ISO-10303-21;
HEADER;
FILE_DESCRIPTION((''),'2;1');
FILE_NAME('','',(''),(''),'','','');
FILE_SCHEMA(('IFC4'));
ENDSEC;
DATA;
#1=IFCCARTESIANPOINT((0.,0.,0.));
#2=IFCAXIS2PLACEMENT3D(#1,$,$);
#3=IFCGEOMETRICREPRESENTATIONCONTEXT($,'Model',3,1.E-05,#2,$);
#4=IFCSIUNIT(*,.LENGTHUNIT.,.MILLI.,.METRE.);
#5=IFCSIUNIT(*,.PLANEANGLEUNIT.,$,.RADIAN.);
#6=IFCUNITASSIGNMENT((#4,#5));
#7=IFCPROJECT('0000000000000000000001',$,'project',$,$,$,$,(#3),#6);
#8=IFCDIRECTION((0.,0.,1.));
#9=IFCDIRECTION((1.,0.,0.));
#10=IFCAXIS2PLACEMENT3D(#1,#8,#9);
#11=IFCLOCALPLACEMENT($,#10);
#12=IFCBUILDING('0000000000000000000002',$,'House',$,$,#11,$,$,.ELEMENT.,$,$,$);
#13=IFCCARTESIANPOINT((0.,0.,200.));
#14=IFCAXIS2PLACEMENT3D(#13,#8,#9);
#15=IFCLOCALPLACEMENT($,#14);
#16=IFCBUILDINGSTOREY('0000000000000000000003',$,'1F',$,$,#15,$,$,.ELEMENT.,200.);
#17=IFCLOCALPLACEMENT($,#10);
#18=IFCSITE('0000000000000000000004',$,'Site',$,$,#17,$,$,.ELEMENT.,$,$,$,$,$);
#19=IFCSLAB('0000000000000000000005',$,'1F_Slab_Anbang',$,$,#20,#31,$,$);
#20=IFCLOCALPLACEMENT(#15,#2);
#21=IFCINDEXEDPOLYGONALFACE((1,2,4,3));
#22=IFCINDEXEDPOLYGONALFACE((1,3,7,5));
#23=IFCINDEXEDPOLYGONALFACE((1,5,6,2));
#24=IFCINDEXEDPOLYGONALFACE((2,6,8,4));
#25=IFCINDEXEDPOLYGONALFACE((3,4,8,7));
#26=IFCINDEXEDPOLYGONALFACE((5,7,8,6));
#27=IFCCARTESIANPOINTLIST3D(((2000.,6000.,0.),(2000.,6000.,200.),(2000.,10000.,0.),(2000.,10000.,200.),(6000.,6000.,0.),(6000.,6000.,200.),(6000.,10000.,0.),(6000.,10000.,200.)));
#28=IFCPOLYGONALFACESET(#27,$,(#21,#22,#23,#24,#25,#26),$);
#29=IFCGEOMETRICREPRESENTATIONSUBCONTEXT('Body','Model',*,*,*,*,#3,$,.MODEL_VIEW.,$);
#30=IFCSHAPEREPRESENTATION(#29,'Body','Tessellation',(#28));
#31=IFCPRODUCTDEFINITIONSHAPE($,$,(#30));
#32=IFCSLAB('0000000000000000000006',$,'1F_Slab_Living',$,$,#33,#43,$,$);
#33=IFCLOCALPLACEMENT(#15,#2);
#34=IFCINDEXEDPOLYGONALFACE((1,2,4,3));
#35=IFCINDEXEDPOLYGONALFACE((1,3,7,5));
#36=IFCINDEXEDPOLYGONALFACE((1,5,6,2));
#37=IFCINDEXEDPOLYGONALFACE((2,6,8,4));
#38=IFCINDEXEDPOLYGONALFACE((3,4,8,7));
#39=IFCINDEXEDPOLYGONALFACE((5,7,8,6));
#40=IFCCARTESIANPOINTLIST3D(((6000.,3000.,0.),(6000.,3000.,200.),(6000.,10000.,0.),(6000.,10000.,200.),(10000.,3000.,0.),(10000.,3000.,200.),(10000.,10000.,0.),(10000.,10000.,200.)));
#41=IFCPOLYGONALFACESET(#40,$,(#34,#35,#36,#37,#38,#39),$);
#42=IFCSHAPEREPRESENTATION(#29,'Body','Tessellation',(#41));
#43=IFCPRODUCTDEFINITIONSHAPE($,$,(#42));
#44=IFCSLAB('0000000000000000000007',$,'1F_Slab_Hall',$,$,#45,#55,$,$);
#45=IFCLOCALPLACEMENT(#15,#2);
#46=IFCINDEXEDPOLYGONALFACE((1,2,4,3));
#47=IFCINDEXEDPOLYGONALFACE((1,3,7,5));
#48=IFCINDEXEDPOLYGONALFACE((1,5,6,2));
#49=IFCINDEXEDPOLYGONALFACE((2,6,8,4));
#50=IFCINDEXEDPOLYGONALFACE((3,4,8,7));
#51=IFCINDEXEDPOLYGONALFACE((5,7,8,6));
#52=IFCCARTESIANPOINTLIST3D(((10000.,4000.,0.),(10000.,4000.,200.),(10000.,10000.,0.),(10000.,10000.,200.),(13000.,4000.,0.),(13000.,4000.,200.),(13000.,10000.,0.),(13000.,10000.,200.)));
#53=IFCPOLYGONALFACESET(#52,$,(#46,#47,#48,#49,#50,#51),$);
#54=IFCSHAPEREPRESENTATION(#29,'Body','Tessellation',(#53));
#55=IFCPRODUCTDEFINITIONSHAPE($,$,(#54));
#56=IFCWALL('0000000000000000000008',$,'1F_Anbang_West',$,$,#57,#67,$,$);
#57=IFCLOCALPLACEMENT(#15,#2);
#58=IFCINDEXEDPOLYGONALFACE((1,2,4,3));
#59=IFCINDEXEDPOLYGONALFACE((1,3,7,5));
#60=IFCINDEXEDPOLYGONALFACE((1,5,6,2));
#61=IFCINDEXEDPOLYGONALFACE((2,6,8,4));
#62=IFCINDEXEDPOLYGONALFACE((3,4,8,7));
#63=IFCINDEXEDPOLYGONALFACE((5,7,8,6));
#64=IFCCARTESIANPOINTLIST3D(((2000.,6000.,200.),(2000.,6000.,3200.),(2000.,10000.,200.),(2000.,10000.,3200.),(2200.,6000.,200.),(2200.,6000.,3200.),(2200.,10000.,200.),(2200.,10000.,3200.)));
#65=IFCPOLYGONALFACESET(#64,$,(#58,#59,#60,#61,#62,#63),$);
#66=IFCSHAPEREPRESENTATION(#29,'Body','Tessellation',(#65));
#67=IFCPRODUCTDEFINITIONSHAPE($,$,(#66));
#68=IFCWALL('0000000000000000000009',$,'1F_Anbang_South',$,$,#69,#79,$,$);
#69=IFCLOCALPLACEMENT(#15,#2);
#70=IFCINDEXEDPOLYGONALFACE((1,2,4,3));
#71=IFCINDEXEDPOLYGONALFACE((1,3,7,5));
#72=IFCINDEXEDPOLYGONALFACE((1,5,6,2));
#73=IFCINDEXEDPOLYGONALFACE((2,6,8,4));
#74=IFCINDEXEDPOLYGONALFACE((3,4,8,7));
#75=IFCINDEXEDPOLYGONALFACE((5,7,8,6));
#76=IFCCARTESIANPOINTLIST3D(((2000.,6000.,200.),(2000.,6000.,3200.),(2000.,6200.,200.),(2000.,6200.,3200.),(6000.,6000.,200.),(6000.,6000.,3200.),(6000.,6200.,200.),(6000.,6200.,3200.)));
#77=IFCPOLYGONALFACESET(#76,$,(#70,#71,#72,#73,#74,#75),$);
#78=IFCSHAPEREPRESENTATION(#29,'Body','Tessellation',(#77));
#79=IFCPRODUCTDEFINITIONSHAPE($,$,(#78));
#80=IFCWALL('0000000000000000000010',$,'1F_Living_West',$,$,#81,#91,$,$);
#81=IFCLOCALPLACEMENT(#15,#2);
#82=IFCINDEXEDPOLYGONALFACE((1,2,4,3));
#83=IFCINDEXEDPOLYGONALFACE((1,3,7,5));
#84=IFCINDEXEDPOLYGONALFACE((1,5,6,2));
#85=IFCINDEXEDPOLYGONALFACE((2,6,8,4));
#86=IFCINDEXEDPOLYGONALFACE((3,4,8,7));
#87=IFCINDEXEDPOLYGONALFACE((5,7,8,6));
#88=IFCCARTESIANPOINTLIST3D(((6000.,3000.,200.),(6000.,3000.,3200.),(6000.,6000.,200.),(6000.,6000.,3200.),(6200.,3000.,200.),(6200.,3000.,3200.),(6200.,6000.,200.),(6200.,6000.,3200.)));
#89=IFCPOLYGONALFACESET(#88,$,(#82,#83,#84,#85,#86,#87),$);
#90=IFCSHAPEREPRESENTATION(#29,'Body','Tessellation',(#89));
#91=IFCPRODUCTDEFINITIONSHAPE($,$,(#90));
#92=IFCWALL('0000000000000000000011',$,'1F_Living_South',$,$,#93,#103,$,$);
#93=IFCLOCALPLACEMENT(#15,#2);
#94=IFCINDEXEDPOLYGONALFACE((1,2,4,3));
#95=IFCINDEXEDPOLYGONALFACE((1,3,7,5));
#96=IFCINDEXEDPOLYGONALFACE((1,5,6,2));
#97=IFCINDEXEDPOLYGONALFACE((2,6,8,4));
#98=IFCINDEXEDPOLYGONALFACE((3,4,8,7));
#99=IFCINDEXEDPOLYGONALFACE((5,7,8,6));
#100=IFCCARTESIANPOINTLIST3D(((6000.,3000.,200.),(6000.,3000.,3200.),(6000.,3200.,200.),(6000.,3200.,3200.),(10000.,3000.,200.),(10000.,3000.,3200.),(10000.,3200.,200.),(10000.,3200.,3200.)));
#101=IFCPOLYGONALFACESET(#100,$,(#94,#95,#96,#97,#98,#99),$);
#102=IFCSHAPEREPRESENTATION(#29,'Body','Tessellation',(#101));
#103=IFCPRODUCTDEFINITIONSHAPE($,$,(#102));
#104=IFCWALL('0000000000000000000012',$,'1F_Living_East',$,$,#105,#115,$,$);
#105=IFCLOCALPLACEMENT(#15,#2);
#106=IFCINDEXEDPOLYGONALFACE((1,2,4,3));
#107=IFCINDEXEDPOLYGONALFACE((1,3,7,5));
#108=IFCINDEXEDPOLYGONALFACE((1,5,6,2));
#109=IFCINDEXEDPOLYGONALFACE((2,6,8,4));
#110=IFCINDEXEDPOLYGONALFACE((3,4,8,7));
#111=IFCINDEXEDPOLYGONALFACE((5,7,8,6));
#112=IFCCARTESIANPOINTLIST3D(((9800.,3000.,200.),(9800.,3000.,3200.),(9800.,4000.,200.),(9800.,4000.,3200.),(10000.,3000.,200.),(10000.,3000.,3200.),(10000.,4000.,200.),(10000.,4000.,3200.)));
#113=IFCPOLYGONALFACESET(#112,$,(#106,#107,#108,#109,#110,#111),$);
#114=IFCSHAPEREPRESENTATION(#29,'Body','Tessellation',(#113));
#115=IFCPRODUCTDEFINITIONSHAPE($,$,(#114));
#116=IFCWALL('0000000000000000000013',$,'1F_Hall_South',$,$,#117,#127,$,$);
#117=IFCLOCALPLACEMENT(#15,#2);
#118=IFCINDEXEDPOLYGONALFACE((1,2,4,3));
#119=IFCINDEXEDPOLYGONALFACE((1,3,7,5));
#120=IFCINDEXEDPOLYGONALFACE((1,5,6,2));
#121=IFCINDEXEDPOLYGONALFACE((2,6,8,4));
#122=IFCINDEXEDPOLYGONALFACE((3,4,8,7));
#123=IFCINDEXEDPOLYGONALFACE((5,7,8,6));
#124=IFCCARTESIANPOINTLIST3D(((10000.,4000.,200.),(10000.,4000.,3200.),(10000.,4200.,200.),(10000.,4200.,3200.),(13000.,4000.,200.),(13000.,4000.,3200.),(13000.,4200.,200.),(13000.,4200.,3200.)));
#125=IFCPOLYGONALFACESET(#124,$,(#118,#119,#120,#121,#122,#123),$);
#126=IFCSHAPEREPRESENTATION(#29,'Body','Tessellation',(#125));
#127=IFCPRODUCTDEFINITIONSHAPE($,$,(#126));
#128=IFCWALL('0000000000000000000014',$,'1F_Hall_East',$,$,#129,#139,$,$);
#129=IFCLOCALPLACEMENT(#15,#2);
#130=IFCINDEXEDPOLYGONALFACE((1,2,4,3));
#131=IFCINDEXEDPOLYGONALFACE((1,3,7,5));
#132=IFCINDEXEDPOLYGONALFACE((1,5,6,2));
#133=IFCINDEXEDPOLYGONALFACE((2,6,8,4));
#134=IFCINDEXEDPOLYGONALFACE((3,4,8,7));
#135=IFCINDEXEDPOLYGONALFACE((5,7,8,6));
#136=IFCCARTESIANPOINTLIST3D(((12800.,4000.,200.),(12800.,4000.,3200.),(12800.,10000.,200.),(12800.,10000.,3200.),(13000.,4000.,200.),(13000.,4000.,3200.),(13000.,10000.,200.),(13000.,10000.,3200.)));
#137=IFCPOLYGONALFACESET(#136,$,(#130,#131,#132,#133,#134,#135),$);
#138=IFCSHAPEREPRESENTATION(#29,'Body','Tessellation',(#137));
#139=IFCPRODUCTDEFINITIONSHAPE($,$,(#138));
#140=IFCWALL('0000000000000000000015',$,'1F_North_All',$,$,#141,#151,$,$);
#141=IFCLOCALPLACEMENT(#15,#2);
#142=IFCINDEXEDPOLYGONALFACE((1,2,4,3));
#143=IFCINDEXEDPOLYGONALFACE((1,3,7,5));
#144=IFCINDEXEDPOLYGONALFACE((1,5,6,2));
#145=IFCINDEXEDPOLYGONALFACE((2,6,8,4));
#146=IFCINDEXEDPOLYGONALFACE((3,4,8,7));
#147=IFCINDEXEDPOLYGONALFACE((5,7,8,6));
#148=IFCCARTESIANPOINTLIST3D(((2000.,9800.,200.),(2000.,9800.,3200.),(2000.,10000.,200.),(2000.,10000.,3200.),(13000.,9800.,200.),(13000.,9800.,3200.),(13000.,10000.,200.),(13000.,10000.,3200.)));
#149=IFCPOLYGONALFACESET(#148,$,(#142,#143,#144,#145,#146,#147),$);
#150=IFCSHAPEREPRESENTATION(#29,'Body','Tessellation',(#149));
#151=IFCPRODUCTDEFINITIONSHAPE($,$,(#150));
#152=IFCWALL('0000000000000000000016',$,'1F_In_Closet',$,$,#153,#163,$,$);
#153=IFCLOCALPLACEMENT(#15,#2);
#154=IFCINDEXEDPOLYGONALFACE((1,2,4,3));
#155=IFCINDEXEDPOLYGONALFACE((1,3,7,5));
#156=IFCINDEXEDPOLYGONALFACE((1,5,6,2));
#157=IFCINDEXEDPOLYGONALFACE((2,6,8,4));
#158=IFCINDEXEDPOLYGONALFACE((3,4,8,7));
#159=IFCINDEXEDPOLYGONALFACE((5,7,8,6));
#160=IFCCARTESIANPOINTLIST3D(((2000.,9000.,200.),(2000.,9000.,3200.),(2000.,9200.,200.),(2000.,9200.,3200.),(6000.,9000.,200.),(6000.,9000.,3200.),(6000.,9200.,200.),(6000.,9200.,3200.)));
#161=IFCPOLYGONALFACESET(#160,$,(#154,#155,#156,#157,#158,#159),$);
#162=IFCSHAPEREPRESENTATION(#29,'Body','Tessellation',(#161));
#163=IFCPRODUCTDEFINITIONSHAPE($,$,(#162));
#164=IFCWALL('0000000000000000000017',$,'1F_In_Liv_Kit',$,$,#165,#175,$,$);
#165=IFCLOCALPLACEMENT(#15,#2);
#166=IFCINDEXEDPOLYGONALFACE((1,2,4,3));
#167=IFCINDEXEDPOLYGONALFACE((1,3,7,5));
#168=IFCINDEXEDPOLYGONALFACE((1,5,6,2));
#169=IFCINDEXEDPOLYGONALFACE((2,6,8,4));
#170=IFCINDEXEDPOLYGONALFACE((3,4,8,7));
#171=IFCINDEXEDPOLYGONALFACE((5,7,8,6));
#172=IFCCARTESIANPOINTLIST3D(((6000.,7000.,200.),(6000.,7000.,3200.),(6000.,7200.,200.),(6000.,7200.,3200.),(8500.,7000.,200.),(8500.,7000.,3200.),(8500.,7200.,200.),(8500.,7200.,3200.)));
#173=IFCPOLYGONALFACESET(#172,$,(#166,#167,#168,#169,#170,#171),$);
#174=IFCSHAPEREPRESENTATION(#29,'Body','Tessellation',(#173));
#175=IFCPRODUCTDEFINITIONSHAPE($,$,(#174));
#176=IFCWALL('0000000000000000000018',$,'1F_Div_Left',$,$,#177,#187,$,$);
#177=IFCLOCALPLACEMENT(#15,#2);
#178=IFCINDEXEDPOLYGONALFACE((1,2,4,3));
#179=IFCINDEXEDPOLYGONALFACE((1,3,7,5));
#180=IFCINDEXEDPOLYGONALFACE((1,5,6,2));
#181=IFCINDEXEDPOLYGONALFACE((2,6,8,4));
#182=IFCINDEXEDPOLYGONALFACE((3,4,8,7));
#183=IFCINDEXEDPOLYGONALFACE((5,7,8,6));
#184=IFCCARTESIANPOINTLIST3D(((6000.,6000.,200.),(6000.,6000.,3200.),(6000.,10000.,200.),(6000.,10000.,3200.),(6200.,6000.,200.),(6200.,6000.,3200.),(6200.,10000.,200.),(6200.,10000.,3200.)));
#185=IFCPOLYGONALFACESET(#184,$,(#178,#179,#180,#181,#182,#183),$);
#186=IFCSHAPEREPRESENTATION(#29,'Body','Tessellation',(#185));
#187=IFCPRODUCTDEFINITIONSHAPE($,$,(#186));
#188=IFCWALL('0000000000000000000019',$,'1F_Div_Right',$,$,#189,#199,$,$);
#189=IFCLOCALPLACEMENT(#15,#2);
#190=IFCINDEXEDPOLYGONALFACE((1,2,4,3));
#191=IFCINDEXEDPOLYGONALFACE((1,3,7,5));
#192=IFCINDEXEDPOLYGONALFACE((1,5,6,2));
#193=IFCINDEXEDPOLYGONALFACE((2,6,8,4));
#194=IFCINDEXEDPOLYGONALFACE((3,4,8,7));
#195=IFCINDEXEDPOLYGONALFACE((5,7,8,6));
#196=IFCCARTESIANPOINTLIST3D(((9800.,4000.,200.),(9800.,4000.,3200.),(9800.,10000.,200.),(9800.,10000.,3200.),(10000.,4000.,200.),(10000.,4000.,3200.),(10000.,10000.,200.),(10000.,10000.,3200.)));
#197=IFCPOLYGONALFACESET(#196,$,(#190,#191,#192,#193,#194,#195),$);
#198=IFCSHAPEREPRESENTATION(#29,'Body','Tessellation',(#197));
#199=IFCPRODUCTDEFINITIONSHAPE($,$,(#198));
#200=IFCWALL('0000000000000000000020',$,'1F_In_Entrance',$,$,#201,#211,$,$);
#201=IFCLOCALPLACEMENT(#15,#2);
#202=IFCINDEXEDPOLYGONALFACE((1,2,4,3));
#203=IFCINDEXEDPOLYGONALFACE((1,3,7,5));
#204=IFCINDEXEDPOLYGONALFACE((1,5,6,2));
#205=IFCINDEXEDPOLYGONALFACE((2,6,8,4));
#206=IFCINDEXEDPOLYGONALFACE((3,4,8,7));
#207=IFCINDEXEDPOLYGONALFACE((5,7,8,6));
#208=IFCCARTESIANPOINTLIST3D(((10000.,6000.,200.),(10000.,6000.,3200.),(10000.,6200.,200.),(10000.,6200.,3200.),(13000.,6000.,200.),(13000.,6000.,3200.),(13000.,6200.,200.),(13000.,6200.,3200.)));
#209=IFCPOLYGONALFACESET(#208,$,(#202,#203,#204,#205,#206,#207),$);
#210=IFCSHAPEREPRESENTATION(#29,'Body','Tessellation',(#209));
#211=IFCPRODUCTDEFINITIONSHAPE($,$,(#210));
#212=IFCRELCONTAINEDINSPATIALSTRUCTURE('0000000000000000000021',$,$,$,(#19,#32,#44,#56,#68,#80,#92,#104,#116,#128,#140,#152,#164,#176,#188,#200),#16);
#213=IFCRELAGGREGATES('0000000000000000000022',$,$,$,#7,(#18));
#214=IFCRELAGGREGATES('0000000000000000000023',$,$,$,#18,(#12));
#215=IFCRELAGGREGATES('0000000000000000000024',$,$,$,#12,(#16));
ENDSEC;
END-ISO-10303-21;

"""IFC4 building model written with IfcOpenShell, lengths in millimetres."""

from ifc_helpers import new_model, si_unit, frame, origin, origin_with_axes, place, context, subcontext, project, spatial, rectangle, extrude, element, save


model = new_model("IFC4")

# Units and contexts
model_context = context("Model", 3, precision=1e-05, world=origin())
body_context = subcontext(model_context, "Body", "Model", "MODEL_VIEW")
ifc_project = project(units=[si_unit("LENGTHUNIT", "METRE", prefix="MILLI"), si_unit("PLANEANGLEUNIT", "RADIAN")], contexts=[model_context])

# Site, building, storey
site_placement = place(None, origin_with_axes())
site = spatial("IfcSite", under=ifc_project, at=site_placement, Name="Site", CompositionType="ELEMENT")
building_placement = place(None, origin_with_axes())
building = spatial("IfcBuilding", under=site, at=building_placement, Name="House", CompositionType="ELEMENT")
storey_placement = place(None, frame((0.0, 0.0, 200.0), z_axis=(0.0, 0.0, 1.0), x_axis=(1.0, 0.0, 0.0)))
storey = spatial("IfcBuildingStorey", under=building, at=storey_placement, Name="1F", CompositionType="ELEMENT", Elevation=200.0)

# Slabs
slab_1_placement = place(None, frame((2000.0, 6000.0, 200.0), z_axis=(0.0, 0.0, 1.0), x_axis=(1.0, 0.0, 0.0)))
element("IfcSlab", 1, at=slab_1_placement, inside=storey, Name="1F_Slab_Anbang", context=body_context, shape_type="SweptSolid", body=[
    extrude(rectangle(XDim=4000.0, YDim=4000.0), frame((2000.0, 2000.0, 0.0)), (0.0, 0.0, 1.0), 200.0),
])
slab_2_placement = place(None, frame((6000.0, 3000.0, 200.0), z_axis=(0.0, 0.0, 1.0), x_axis=(1.0, 0.0, 0.0)))
element("IfcSlab", 2, at=slab_2_placement, inside=storey, Name="1F_Slab_Living", context=body_context, shape_type="SweptSolid", body=[
    extrude(rectangle(XDim=4000.0, YDim=7000.0), frame((2000.0, 3500.0, 0.0)), (0.0, 0.0, 1.0), 200.0),
])
slab_3_placement = place(None, frame((10000.0, 4000.0, 200.0), z_axis=(0.0, 0.0, 1.0), x_axis=(1.0, 0.0, 0.0)))
element("IfcSlab", 3, at=slab_3_placement, inside=storey, Name="1F_Slab_Hall", context=body_context, shape_type="SweptSolid", body=[
    extrude(rectangle(XDim=3000.0, YDim=6000.0), frame((1500.0, 3000.0, 0.0)), (0.0, 0.0, 1.0), 200.0),
])

# Walls
wall_1_placement = place(None, frame((2000.0, 6000.0, 400.0), z_axis=(0.0, 0.0, 1.0), x_axis=(1.0, 0.0, 0.0)))
element("IfcWall", 4, at=wall_1_placement, inside=storey, Name="1F_Anbang_West", context=body_context, shape_type="SweptSolid", body=[
    extrude(rectangle(XDim=200.0, YDim=4000.0), frame((100.0, 2000.0, 0.0)), (0.0, 0.0, 1.0), 3000.0),
])
wall_2_placement = place(None, frame((2000.0, 6000.0, 400.0), z_axis=(0.0, 0.0, 1.0), x_axis=(1.0, 0.0, 0.0)))
element("IfcWall", 5, at=wall_2_placement, inside=storey, Name="1F_Anbang_South", context=body_context, shape_type="SweptSolid", body=[
    extrude(rectangle(XDim=4000.0, YDim=200.0), frame((2000.0, 100.0, 0.0)), (0.0, 0.0, 1.0), 3000.0),
])
wall_3_placement = place(None, frame((6000.0, 3000.0, 400.0), z_axis=(0.0, 0.0, 1.0), x_axis=(1.0, 0.0, 0.0)))
element("IfcWall", 6, at=wall_3_placement, inside=storey, Name="1F_Living_West", context=body_context, shape_type="SweptSolid", body=[
    extrude(rectangle(XDim=200.0, YDim=3000.0), frame((100.0, 1500.0, 0.0)), (0.0, 0.0, 1.0), 3000.0),
])
wall_4_placement = place(None, frame((6000.0, 3000.0, 400.0), z_axis=(0.0, 0.0, 1.0), x_axis=(1.0, 0.0, 0.0)))
element("IfcWall", 7, at=wall_4_placement, inside=storey, Name="1F_Living_South", context=body_context, shape_type="SweptSolid", body=[
    extrude(rectangle(XDim=4000.0, YDim=200.0), frame((2000.0, 100.0, 0.0)), (0.0, 0.0, 1.0), 3000.0),
])
wall_5_placement = place(None, frame((9800.0, 3000.0, 400.0), z_axis=(0.0, 0.0, 1.0), x_axis=(1.0, 0.0, 0.0)))
element("IfcWall", 8, at=wall_5_placement, inside=storey, Name="1F_Living_East", context=body_context, shape_type="SweptSolid", body=[
    extrude(rectangle(XDim=200.0, YDim=1000.0), frame((100.0, 500.0, 0.0)), (0.0, 0.0, 1.0), 3000.0),
])
wall_6_placement = place(None, frame((10000.0, 4000.0, 400.0), z_axis=(0.0, 0.0, 1.0), x_axis=(1.0, 0.0, 0.0)))
element("IfcWall", 9, at=wall_6_placement, inside=storey, Name="1F_Hall_South", context=body_context, shape_type="SweptSolid", body=[
    extrude(rectangle(XDim=3000.0, YDim=200.0), frame((1500.0, 100.0, 0.0)), (0.0, 0.0, 1.0), 3000.0),
])
wall_7_placement = place(None, frame((12800.0, 4000.0, 400.0), z_axis=(0.0, 0.0, 1.0), x_axis=(1.0, 0.0, 0.0)))
element("IfcWall", 10, at=wall_7_placement, inside=storey, Name="1F_Hall_East", context=body_context, shape_type="SweptSolid", body=[
    extrude(rectangle(XDim=200.0, YDim=6000.0), frame((100.0, 3000.0, 0.0)), (0.0, 0.0, 1.0), 3000.0),
])
wall_8_placement = place(None, frame((2000.0, 9800.0, 400.0), z_axis=(0.0, 0.0, 1.0), x_axis=(1.0, 0.0, 0.0)))
element("IfcWall", 11, at=wall_8_placement, inside=storey, Name="1F_North_All", context=body_context, shape_type="SweptSolid", body=[
    extrude(rectangle(XDim=11000.0, YDim=200.0), frame((5500.0, 100.0, 0.0)), (0.0, 0.0, 1.0), 3000.0),
])
wall_9_placement = place(None, frame((2000.0, 9000.0, 400.0), z_axis=(0.0, 0.0, 1.0), x_axis=(1.0, 0.0, 0.0)))
element("IfcWall", 12, at=wall_9_placement, inside=storey, Name="1F_In_Closet", context=body_context, shape_type="SweptSolid", body=[
    extrude(rectangle(XDim=4000.0, YDim=200.0), frame((2000.0, 100.0, 0.0)), (0.0, 0.0, 1.0), 3000.0),
])
wall_10_placement = place(None, frame((6000.0, 7000.0, 400.0), z_axis=(0.0, 0.0, 1.0), x_axis=(1.0, 0.0, 0.0)))
element("IfcWall", 13, at=wall_10_placement, inside=storey, Name="1F_In_Liv_Kit", context=body_context, shape_type="SweptSolid", body=[
    extrude(rectangle(XDim=2500.0, YDim=200.0), frame((1250.0, 100.0, 0.0)), (0.0, 0.0, 1.0), 3000.0),
])
wall_11_placement = place(None, frame((6000.0, 6000.0, 400.0), z_axis=(0.0, 0.0, 1.0), x_axis=(1.0, 0.0, 0.0)))
element("IfcWall", 14, at=wall_11_placement, inside=storey, Name="1F_Div_Left", context=body_context, shape_type="SweptSolid", body=[
    extrude(rectangle(XDim=200.0, YDim=4000.0), frame((100.0, 2000.0, 0.0)), (0.0, 0.0, 1.0), 3000.0),
])
wall_12_placement = place(None, frame((9800.0, 4000.0, 400.0), z_axis=(0.0, 0.0, 1.0), x_axis=(1.0, 0.0, 0.0)))
element("IfcWall", 15, at=wall_12_placement, inside=storey, Name="1F_Div_Right", context=body_context, shape_type="SweptSolid", body=[
    extrude(rectangle(XDim=200.0, YDim=6000.0), frame((100.0, 3000.0, 0.0)), (0.0, 0.0, 1.0), 3000.0),
])
wall_13_placement = place(None, frame((10000.0, 6000.0, 400.0), z_axis=(0.0, 0.0, 1.0), x_axis=(1.0, 0.0, 0.0)))
element("IfcWall", 16, at=wall_13_placement, inside=storey, Name="1F_In_Entrance", context=body_context, shape_type="SweptSolid", body=[
    extrude(rectangle(XDim=3000.0, YDim=200.0), frame((1500.0, 100.0, 0.0)), (0.0, 0.0, 1.0), 3000.0),
])

save(model, "model.ifc")
